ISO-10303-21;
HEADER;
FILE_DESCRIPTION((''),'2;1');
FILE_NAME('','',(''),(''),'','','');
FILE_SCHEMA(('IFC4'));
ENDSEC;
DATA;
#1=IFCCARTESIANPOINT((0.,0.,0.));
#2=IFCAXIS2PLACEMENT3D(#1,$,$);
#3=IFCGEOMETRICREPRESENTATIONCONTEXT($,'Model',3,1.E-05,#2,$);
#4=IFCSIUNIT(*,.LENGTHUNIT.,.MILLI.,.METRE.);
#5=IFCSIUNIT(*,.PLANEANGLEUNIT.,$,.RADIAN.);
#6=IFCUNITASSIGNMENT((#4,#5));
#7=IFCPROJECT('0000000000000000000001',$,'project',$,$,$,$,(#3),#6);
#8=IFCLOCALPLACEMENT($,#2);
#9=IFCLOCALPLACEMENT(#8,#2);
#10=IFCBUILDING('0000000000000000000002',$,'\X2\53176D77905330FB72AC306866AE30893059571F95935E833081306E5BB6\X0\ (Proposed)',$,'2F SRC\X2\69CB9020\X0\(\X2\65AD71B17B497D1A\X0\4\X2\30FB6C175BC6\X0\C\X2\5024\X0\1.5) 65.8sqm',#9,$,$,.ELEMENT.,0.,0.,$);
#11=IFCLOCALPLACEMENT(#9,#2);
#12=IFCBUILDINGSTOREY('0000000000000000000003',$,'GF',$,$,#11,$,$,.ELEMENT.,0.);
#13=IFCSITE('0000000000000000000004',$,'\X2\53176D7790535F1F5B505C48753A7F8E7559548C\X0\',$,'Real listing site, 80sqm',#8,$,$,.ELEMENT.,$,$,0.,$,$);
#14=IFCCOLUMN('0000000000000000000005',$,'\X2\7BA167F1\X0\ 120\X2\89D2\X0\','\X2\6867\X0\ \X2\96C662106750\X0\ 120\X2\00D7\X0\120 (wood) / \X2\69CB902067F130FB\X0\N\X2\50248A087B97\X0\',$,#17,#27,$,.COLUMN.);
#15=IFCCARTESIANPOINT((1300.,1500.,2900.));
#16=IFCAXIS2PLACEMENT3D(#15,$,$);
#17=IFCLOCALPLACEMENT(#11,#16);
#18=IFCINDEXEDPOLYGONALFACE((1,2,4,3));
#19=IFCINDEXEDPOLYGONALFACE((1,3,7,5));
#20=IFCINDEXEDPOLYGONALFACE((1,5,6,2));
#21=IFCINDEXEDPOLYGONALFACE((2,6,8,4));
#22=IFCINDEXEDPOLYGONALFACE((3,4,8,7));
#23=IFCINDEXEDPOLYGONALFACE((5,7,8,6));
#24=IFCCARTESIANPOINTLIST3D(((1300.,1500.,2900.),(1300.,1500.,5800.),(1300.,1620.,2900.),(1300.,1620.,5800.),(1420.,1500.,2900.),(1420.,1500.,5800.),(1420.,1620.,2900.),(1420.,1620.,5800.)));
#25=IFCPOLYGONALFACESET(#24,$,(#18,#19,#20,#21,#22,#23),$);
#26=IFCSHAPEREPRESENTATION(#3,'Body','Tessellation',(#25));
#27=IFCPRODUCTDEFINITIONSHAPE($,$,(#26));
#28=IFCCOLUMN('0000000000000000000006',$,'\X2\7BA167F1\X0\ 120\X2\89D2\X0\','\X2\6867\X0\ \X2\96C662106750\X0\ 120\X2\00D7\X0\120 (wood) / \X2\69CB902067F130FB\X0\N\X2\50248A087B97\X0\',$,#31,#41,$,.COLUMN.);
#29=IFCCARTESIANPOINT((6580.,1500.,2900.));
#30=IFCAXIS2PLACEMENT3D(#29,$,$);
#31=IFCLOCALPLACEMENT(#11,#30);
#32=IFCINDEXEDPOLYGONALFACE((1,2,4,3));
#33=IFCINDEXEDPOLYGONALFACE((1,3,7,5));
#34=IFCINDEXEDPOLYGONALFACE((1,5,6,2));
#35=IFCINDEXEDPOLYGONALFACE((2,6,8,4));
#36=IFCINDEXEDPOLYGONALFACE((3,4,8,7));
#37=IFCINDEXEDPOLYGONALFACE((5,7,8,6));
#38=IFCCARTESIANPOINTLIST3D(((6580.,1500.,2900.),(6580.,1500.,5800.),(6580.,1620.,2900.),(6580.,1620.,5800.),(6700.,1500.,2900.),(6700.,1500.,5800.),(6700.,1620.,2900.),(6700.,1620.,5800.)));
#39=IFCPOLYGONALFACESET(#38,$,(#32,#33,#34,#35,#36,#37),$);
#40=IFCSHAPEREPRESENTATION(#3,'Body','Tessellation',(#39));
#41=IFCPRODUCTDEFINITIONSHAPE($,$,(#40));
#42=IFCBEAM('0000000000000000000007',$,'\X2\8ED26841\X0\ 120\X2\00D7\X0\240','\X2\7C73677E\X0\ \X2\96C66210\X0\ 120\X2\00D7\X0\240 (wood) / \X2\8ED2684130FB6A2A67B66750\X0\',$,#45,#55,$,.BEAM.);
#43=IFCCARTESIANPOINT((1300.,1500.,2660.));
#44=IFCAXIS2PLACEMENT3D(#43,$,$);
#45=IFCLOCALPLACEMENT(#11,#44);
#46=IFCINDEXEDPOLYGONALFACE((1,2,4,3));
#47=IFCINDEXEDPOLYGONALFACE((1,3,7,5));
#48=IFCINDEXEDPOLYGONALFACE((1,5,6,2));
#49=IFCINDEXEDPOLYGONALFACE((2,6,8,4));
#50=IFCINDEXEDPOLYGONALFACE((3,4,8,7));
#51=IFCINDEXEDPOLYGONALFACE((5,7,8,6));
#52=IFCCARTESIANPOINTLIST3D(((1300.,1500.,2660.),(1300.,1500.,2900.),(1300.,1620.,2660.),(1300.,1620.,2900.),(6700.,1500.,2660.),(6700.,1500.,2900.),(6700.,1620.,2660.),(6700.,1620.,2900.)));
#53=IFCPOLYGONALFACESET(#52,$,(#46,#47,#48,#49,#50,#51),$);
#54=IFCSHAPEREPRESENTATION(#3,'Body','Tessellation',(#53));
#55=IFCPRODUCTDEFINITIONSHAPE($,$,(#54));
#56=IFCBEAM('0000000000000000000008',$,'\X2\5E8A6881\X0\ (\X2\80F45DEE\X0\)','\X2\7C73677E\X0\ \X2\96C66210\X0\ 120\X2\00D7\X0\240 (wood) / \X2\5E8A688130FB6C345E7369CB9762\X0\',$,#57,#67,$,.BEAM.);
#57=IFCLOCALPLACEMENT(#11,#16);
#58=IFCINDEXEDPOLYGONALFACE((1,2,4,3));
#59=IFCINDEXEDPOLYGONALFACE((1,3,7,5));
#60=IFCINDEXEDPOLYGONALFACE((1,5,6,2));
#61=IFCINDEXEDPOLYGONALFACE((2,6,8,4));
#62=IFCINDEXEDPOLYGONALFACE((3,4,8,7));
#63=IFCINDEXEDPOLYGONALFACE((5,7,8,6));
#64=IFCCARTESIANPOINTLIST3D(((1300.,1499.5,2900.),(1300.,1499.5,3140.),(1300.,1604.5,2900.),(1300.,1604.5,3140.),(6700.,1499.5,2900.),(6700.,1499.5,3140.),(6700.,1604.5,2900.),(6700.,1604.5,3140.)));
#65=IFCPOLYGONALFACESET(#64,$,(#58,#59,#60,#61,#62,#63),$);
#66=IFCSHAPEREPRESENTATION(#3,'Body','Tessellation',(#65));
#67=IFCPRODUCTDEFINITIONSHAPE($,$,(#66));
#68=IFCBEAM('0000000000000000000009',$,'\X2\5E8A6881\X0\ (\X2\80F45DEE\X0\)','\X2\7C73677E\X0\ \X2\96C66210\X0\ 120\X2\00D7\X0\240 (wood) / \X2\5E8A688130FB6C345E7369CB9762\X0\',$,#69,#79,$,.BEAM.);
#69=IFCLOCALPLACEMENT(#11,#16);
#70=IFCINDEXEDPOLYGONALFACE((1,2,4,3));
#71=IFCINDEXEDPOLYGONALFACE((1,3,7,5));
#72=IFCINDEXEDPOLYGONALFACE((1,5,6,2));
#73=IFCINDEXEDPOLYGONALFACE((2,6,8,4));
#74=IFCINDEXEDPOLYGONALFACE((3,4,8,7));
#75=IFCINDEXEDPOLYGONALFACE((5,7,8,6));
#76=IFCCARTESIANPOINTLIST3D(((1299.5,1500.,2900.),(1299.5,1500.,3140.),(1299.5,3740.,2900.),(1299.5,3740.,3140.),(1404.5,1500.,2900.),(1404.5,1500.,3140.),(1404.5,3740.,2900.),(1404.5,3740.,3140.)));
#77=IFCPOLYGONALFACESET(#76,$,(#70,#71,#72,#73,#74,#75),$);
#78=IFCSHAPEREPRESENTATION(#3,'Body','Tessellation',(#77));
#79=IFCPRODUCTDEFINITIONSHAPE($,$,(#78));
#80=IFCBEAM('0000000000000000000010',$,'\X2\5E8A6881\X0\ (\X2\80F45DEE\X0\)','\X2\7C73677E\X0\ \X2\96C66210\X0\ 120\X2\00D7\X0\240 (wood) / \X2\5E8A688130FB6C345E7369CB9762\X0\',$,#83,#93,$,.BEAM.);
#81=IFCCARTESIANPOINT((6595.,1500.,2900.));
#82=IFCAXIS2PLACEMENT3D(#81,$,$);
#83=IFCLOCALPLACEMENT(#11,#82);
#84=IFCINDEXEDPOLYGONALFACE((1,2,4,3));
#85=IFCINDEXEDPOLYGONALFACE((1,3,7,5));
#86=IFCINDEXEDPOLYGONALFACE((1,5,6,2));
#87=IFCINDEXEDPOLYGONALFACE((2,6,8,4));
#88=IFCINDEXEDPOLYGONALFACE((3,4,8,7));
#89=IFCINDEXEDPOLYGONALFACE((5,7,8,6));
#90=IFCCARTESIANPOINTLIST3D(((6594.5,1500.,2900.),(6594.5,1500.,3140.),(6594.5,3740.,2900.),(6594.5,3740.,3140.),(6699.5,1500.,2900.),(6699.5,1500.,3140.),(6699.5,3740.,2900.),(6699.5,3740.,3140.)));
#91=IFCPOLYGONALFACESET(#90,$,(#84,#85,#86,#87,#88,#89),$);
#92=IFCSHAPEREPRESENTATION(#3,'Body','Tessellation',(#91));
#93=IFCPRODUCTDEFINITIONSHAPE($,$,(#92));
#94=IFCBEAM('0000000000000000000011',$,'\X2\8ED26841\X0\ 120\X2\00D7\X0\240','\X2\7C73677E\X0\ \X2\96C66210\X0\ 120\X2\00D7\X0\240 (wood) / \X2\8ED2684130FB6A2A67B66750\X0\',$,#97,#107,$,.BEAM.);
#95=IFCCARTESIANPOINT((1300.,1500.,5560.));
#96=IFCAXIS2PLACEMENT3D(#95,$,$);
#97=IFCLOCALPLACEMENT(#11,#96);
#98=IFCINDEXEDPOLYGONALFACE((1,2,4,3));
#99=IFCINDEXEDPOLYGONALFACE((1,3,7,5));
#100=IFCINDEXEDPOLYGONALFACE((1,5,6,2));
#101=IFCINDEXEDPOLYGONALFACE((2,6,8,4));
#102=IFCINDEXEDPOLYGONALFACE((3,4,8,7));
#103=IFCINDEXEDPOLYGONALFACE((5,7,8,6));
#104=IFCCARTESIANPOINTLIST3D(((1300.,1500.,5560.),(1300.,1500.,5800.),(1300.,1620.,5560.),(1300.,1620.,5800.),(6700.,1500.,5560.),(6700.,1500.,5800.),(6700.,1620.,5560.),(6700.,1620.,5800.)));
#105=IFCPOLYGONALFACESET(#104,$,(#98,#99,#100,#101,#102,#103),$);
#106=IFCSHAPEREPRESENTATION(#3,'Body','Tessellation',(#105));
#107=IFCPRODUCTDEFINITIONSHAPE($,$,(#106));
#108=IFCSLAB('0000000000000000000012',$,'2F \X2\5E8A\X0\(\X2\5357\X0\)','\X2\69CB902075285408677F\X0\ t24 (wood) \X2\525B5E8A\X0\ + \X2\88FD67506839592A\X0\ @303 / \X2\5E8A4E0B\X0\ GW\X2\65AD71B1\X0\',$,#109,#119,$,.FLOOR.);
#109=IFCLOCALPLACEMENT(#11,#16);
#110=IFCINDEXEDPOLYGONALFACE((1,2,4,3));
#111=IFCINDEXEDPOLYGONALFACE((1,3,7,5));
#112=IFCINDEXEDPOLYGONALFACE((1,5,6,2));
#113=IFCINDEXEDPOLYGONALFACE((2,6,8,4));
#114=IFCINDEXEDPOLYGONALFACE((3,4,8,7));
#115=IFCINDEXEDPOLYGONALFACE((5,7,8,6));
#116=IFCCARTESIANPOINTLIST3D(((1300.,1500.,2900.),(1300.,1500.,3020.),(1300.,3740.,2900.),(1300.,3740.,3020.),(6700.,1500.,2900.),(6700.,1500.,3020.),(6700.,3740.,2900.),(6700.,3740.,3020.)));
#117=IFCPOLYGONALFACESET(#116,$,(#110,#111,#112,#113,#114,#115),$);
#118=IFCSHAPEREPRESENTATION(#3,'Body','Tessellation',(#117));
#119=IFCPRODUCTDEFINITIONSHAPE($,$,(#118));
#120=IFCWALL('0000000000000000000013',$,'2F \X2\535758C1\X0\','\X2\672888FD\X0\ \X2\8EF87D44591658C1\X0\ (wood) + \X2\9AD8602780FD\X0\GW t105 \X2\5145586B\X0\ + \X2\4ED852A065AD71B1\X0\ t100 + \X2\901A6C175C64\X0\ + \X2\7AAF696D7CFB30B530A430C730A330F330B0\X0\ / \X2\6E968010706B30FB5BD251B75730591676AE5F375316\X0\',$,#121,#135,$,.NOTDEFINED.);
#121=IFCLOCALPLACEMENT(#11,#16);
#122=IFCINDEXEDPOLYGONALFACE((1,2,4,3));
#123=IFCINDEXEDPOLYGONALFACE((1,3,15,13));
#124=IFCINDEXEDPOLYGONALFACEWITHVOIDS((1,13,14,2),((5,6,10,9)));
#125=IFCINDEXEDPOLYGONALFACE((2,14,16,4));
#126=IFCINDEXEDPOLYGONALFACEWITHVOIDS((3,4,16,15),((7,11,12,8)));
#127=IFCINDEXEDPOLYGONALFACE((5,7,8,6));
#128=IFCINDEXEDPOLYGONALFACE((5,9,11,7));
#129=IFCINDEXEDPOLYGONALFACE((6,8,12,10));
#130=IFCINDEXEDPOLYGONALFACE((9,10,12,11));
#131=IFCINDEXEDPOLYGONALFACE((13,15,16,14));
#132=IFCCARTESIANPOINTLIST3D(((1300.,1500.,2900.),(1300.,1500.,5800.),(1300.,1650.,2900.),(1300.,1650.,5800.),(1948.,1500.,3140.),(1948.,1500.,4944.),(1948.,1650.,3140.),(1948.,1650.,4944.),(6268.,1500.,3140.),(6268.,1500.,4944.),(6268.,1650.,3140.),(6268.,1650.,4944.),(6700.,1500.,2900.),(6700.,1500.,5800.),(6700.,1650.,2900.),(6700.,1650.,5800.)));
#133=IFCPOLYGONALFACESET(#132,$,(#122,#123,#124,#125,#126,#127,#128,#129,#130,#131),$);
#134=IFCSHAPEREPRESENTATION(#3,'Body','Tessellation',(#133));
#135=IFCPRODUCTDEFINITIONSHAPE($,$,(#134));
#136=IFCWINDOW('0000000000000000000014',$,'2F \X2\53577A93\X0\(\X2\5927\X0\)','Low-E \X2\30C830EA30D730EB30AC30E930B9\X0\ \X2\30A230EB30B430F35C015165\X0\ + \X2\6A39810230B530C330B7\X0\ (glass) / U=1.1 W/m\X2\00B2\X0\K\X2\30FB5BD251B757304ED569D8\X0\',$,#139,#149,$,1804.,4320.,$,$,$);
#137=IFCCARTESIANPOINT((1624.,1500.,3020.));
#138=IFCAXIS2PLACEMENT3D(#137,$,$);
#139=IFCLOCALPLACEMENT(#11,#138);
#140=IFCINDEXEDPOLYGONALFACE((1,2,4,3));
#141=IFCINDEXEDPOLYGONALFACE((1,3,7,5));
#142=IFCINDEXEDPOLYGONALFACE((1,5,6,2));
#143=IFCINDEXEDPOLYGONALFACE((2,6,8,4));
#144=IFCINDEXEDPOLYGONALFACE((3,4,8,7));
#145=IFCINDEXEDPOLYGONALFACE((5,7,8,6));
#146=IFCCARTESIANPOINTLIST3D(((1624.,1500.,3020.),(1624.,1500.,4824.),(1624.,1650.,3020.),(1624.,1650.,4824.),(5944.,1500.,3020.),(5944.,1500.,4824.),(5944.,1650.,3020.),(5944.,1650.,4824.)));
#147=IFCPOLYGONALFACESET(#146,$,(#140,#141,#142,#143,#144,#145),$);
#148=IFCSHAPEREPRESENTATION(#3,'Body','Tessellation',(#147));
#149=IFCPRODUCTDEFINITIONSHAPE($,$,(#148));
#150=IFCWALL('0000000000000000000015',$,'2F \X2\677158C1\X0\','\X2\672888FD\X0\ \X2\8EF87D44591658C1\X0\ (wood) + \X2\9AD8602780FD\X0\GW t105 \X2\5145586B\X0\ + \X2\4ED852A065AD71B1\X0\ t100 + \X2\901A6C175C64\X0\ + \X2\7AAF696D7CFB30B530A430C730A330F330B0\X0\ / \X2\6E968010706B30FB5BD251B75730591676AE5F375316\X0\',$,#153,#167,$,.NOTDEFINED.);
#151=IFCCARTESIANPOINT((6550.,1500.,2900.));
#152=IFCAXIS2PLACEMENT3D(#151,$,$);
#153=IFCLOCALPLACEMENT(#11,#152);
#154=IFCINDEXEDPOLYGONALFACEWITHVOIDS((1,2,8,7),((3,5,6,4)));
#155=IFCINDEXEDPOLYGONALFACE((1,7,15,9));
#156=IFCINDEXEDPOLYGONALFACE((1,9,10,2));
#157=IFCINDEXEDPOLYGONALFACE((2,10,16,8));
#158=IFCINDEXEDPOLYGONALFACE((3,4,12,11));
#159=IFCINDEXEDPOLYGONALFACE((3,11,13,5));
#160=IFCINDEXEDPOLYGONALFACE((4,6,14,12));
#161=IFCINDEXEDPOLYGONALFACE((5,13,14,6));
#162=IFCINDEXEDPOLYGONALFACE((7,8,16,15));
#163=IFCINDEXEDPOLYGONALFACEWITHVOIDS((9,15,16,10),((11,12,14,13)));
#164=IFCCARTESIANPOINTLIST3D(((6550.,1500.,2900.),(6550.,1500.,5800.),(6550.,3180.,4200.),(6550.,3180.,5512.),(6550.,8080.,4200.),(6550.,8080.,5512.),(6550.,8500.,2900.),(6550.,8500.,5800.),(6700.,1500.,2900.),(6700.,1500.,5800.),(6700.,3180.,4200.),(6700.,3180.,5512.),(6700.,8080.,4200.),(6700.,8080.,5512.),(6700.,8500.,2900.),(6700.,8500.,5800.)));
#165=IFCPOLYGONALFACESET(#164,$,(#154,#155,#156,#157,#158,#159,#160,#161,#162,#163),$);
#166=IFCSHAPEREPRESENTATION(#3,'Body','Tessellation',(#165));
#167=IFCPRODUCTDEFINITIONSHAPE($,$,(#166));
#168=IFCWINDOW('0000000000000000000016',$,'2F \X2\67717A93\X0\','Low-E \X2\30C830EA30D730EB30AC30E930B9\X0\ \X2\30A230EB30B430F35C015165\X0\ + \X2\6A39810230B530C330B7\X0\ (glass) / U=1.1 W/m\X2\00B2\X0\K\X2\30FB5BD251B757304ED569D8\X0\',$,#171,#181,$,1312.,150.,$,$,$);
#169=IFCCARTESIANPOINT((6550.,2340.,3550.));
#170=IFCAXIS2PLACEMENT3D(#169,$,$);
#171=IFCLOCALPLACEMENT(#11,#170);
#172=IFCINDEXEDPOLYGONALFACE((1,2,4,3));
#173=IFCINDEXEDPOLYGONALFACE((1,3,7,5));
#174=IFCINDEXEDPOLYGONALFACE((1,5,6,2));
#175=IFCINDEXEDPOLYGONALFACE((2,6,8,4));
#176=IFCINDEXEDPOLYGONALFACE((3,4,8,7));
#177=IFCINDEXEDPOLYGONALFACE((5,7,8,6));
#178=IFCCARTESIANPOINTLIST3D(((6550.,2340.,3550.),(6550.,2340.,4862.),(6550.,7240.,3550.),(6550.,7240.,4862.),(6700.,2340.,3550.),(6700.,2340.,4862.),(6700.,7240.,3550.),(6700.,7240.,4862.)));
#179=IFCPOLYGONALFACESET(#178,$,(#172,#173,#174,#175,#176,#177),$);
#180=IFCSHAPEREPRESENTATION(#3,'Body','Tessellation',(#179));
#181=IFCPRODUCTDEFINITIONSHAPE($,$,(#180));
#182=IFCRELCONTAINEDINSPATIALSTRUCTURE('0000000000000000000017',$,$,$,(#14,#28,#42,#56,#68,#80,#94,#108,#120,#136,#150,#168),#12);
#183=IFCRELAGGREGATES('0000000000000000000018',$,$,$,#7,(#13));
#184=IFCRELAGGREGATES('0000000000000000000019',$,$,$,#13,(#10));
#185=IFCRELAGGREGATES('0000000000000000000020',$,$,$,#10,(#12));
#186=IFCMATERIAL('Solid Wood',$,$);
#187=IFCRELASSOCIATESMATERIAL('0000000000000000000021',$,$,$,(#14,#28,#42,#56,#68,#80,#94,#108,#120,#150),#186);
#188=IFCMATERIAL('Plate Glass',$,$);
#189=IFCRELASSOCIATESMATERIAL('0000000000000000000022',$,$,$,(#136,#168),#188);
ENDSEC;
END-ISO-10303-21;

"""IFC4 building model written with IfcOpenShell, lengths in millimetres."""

from ifc_helpers import new_model, si_unit, frame, frame_2d, origin, place, context, project, spatial, rectangle, extrude, material, element, fill, save


model = new_model("IFC4")

# Units and contexts
model_context = context("Model", 3, precision=1e-05, world=origin())
ifc_project = project(units=[si_unit("LENGTHUNIT", "METRE", prefix="MILLI"), si_unit("PLANEANGLEUNIT", "RADIAN")], contexts=[model_context])

# Site, building, storey
site_placement = place(None, origin())
site = spatial("IfcSite", under=ifc_project, at=site_placement, Name="北海道弟子屈町美留和", ObjectType="Real listing site, 80sqm", CompositionType="ELEMENT", RefElevation=0.0)
building_placement = place(site_placement, origin())
building = spatial("IfcBuilding", under=site, at=building_placement, Name="北海道・犬と暮らす土間広めの家 (Proposed)", ObjectType="2F SRC構造(断熱等級4・気密C値1.5) 65.8sqm", CompositionType="ELEMENT", ElevationOfRefHeight=0.0, ElevationOfTerrain=0.0)
storey_placement = place(building_placement, origin())
storey = spatial("IfcBuildingStorey", under=building, at=storey_placement, Name="GF", CompositionType="ELEMENT", Elevation=0.0)

# Columns
ifc_material_1 = material(Name="Solid Wood")
column_1_placement = place(storey_placement, frame((1300.0, 1500.0, 2900.0)))
element("IfcColumn", 1, at=column_1_placement, inside=storey, material=ifc_material_1, Name="管柱 120角", Description="桧 集成材 120×120 (wood) / 構造柱・N値計算", PredefinedType="COLUMN", context=model_context, shape_type="SweptSolid", body=[
    extrude(rectangle(XDim=120.0, YDim=120.0, at=frame_2d((60.0, 60.0))), frame((1300.0, 1500.0, 2900.0)), (0.0, 0.0, 1.0), 2900.0),
])
column_2_placement = place(storey_placement, frame((6580.0, 1500.0, 2900.0)))
element("IfcColumn", 2, at=column_2_placement, inside=storey, material=ifc_material_1, Name="管柱 120角", Description="桧 集成材 120×120 (wood) / 構造柱・N値計算", PredefinedType="COLUMN", context=model_context, shape_type="SweptSolid", body=[
    extrude(rectangle(XDim=120.0, YDim=120.0, at=frame_2d((60.0, 60.0))), frame((6580.0, 1500.0, 2900.0)), (0.0, 0.0, 1.0), 2900.0),
])

# Beams
beam_1_placement = place(storey_placement, frame((1300.0, 1500.0, 2660.0)))
element("IfcBeam", 3, at=beam_1_placement, inside=storey, material=ifc_material_1, Name="軒桁 120×240", Description="米松 集成 120×240 (wood) / 軒桁・横架材", PredefinedType="BEAM", context=model_context, shape_type="SweptSolid", body=[
    extrude(rectangle(XDim=5400.0, YDim=120.0, at=frame_2d((2700.0, 60.0))), frame((1300.0, 1500.0, 2660.0)), (0.0, 0.0, 1.0), 240.0),
])
beam_2_placement = place(storey_placement, frame((1300.0, 1500.0, 2900.0)))
element("IfcBeam", 4, at=beam_2_placement, inside=storey, material=ifc_material_1, Name="床梁 (胴差)", Description="米松 集成 120×240 (wood) / 床梁・水平構面", PredefinedType="BEAM", context=model_context, shape_type="SweptSolid", body=[
    extrude(rectangle(XDim=5400.0, YDim=105.0, at=frame_2d((2700.0, 52.0))), frame((1300.0, 1500.0, 2900.0)), (0.0, 0.0, 1.0), 240.0),
])
beam_3_placement = place(storey_placement, frame((1300.0, 1500.0, 2900.0)))
element("IfcBeam", 5, at=beam_3_placement, inside=storey, material=ifc_material_1, Name="床梁 (胴差)", Description="米松 集成 120×240 (wood) / 床梁・水平構面", PredefinedType="BEAM", context=model_context, shape_type="SweptSolid", body=[
    extrude(rectangle(XDim=105.0, YDim=2240.0, at=frame_2d((52.0, 1120.0))), frame((1300.0, 1500.0, 2900.0)), (0.0, 0.0, 1.0), 240.0),
])
beam_4_placement = place(storey_placement, frame((6595.0, 1500.0, 2900.0)))
element("IfcBeam", 6, at=beam_4_placement, inside=storey, material=ifc_material_1, Name="床梁 (胴差)", Description="米松 集成 120×240 (wood) / 床梁・水平構面", PredefinedType="BEAM", context=model_context, shape_type="SweptSolid", body=[
    extrude(rectangle(XDim=105.0, YDim=2240.0, at=frame_2d((52.0, 1120.0))), frame((6595.0, 1500.0, 2900.0)), (0.0, 0.0, 1.0), 240.0),
])
beam_5_placement = place(storey_placement, frame((1300.0, 1500.0, 5560.0)))
element("IfcBeam", 7, at=beam_5_placement, inside=storey, material=ifc_material_1, Name="軒桁 120×240", Description="米松 集成 120×240 (wood) / 軒桁・横架材", PredefinedType="BEAM", context=model_context, shape_type="SweptSolid", body=[
    extrude(rectangle(XDim=5400.0, YDim=120.0, at=frame_2d((2700.0, 60.0))), frame((1300.0, 1500.0, 5560.0)), (0.0, 0.0, 1.0), 240.0),
])

# Slab
slab_placement = place(storey_placement, frame((1300.0, 1500.0, 2900.0)))
element("IfcSlab", 8, at=slab_placement, inside=storey, material=ifc_material_1, Name="2F 床(南)", Description="構造用合板 t24 (wood) 剛床 + 製材根太 @303 / 床下 GW断熱", PredefinedType="FLOOR", context=model_context, shape_type="SweptSolid", body=[
    extrude(rectangle(XDim=5400.0, YDim=2240.0, at=frame_2d((2700.0, 1120.0))), frame((1300.0, 1500.0, 2900.0)), (0.0, 0.0, 1.0), 120.0),
])

# Walls, openings, windows
wall_1_placement = place(storey_placement, frame((1300.0, 1500.0, 2900.0)))
wall_1 = element("IfcWall", 9, at=wall_1_placement, inside=storey, material=ifc_material_1, Name="2F 南壁", Description="木製 軸組外壁 (wood) + 高性能GW t105 充填 + 付加断熱 t100 + 通気層 + 窯業系サイディング / 準耐火・寒冷地外皮強化", PredefinedType="NOTDEFINED", context=model_context, shape_type="SweptSolid", body=[
    extrude(rectangle(XDim=5400.0, YDim=150.0, at=frame_2d((2700.0, 75.0))), frame((1300.0, 1500.0, 2900.0)), (0.0, 0.0, 1.0), 2900.0),
])
opening_1_placement = place(storey_placement, frame((1624.0, 1500.0, 3020.0)))
opening_1 = element("IfcOpeningElement", 10, at=opening_1_placement, cuts=wall_1, PredefinedType="NOTDEFINED", context=model_context, shape_type="SweptSolid", body=[
    extrude(rectangle(XDim=4320.0, YDim=150.0, at=frame_2d((2160.0, 75.0))), frame((1624.0, 1500.0, 3020.0)), (0.0, 0.0, 1.0), 1804.0),
])
ifc_material_2 = material(Name="Plate Glass")
window_1_placement = place(storey_placement, frame((1624.0, 1500.0, 3020.0)))
window_1 = element("IfcWindow", 11, at=window_1_placement, inside=storey, material=ifc_material_2, Name="2F 南窓(大)", Description="Low-E トリプルガラス アルゴン封入 + 樹脂サッシ (glass) / U=1.1 W/m²K・寒冷地仕様", OverallHeight=1804.0, OverallWidth=4320.0, context=model_context, shape_type="SweptSolid", body=[
    extrude(rectangle(XDim=4320.0, YDim=150.0, at=frame_2d((2160.0, 75.0))), frame((1624.0, 1500.0, 3020.0)), (0.0, 0.0, 1.0), 1804.0),
])
fill(opening_1, window_1)
wall_2_placement = place(storey_placement, frame((6550.0, 1500.0, 2900.0)))
wall_2 = element("IfcWall", 12, at=wall_2_placement, inside=storey, material=ifc_material_1, Name="2F 東壁", Description="木製 軸組外壁 (wood) + 高性能GW t105 充填 + 付加断熱 t100 + 通気層 + 窯業系サイディング / 準耐火・寒冷地外皮強化", PredefinedType="NOTDEFINED", context=model_context, shape_type="SweptSolid", body=[
    extrude(rectangle(XDim=150.0, YDim=7000.0, at=frame_2d((75.0, 3500.0))), frame((6550.0, 1500.0, 2900.0)), (0.0, 0.0, 1.0), 2900.0),
])
opening_2_placement = place(storey_placement, frame((6550.0, 2340.0, 3550.0)))
opening_2 = element("IfcOpeningElement", 13, at=opening_2_placement, cuts=wall_2, PredefinedType="NOTDEFINED", context=model_context, shape_type="SweptSolid", body=[
    extrude(rectangle(XDim=150.0, YDim=4900.0, at=frame_2d((75.0, 2450.0))), frame((6550.0, 2340.0, 3550.0)), (0.0, 0.0, 1.0), 1312.0),
])
window_2_placement = place(storey_placement, frame((6550.0, 2340.0, 3550.0)))
window_2 = element("IfcWindow", 14, at=window_2_placement, inside=storey, material=ifc_material_2, Name="2F 東窓", Description="Low-E トリプルガラス アルゴン封入 + 樹脂サッシ (glass) / U=1.1 W/m²K・寒冷地仕様", OverallHeight=1312.0, OverallWidth=150.0, context=model_context, shape_type="SweptSolid", body=[
    extrude(rectangle(XDim=150.0, YDim=4900.0, at=frame_2d((75.0, 2450.0))), frame((6550.0, 2340.0, 3550.0)), (0.0, 0.0, 1.0), 1312.0),
])
fill(opening_2, window_2)

save(model, "model.ifc")
